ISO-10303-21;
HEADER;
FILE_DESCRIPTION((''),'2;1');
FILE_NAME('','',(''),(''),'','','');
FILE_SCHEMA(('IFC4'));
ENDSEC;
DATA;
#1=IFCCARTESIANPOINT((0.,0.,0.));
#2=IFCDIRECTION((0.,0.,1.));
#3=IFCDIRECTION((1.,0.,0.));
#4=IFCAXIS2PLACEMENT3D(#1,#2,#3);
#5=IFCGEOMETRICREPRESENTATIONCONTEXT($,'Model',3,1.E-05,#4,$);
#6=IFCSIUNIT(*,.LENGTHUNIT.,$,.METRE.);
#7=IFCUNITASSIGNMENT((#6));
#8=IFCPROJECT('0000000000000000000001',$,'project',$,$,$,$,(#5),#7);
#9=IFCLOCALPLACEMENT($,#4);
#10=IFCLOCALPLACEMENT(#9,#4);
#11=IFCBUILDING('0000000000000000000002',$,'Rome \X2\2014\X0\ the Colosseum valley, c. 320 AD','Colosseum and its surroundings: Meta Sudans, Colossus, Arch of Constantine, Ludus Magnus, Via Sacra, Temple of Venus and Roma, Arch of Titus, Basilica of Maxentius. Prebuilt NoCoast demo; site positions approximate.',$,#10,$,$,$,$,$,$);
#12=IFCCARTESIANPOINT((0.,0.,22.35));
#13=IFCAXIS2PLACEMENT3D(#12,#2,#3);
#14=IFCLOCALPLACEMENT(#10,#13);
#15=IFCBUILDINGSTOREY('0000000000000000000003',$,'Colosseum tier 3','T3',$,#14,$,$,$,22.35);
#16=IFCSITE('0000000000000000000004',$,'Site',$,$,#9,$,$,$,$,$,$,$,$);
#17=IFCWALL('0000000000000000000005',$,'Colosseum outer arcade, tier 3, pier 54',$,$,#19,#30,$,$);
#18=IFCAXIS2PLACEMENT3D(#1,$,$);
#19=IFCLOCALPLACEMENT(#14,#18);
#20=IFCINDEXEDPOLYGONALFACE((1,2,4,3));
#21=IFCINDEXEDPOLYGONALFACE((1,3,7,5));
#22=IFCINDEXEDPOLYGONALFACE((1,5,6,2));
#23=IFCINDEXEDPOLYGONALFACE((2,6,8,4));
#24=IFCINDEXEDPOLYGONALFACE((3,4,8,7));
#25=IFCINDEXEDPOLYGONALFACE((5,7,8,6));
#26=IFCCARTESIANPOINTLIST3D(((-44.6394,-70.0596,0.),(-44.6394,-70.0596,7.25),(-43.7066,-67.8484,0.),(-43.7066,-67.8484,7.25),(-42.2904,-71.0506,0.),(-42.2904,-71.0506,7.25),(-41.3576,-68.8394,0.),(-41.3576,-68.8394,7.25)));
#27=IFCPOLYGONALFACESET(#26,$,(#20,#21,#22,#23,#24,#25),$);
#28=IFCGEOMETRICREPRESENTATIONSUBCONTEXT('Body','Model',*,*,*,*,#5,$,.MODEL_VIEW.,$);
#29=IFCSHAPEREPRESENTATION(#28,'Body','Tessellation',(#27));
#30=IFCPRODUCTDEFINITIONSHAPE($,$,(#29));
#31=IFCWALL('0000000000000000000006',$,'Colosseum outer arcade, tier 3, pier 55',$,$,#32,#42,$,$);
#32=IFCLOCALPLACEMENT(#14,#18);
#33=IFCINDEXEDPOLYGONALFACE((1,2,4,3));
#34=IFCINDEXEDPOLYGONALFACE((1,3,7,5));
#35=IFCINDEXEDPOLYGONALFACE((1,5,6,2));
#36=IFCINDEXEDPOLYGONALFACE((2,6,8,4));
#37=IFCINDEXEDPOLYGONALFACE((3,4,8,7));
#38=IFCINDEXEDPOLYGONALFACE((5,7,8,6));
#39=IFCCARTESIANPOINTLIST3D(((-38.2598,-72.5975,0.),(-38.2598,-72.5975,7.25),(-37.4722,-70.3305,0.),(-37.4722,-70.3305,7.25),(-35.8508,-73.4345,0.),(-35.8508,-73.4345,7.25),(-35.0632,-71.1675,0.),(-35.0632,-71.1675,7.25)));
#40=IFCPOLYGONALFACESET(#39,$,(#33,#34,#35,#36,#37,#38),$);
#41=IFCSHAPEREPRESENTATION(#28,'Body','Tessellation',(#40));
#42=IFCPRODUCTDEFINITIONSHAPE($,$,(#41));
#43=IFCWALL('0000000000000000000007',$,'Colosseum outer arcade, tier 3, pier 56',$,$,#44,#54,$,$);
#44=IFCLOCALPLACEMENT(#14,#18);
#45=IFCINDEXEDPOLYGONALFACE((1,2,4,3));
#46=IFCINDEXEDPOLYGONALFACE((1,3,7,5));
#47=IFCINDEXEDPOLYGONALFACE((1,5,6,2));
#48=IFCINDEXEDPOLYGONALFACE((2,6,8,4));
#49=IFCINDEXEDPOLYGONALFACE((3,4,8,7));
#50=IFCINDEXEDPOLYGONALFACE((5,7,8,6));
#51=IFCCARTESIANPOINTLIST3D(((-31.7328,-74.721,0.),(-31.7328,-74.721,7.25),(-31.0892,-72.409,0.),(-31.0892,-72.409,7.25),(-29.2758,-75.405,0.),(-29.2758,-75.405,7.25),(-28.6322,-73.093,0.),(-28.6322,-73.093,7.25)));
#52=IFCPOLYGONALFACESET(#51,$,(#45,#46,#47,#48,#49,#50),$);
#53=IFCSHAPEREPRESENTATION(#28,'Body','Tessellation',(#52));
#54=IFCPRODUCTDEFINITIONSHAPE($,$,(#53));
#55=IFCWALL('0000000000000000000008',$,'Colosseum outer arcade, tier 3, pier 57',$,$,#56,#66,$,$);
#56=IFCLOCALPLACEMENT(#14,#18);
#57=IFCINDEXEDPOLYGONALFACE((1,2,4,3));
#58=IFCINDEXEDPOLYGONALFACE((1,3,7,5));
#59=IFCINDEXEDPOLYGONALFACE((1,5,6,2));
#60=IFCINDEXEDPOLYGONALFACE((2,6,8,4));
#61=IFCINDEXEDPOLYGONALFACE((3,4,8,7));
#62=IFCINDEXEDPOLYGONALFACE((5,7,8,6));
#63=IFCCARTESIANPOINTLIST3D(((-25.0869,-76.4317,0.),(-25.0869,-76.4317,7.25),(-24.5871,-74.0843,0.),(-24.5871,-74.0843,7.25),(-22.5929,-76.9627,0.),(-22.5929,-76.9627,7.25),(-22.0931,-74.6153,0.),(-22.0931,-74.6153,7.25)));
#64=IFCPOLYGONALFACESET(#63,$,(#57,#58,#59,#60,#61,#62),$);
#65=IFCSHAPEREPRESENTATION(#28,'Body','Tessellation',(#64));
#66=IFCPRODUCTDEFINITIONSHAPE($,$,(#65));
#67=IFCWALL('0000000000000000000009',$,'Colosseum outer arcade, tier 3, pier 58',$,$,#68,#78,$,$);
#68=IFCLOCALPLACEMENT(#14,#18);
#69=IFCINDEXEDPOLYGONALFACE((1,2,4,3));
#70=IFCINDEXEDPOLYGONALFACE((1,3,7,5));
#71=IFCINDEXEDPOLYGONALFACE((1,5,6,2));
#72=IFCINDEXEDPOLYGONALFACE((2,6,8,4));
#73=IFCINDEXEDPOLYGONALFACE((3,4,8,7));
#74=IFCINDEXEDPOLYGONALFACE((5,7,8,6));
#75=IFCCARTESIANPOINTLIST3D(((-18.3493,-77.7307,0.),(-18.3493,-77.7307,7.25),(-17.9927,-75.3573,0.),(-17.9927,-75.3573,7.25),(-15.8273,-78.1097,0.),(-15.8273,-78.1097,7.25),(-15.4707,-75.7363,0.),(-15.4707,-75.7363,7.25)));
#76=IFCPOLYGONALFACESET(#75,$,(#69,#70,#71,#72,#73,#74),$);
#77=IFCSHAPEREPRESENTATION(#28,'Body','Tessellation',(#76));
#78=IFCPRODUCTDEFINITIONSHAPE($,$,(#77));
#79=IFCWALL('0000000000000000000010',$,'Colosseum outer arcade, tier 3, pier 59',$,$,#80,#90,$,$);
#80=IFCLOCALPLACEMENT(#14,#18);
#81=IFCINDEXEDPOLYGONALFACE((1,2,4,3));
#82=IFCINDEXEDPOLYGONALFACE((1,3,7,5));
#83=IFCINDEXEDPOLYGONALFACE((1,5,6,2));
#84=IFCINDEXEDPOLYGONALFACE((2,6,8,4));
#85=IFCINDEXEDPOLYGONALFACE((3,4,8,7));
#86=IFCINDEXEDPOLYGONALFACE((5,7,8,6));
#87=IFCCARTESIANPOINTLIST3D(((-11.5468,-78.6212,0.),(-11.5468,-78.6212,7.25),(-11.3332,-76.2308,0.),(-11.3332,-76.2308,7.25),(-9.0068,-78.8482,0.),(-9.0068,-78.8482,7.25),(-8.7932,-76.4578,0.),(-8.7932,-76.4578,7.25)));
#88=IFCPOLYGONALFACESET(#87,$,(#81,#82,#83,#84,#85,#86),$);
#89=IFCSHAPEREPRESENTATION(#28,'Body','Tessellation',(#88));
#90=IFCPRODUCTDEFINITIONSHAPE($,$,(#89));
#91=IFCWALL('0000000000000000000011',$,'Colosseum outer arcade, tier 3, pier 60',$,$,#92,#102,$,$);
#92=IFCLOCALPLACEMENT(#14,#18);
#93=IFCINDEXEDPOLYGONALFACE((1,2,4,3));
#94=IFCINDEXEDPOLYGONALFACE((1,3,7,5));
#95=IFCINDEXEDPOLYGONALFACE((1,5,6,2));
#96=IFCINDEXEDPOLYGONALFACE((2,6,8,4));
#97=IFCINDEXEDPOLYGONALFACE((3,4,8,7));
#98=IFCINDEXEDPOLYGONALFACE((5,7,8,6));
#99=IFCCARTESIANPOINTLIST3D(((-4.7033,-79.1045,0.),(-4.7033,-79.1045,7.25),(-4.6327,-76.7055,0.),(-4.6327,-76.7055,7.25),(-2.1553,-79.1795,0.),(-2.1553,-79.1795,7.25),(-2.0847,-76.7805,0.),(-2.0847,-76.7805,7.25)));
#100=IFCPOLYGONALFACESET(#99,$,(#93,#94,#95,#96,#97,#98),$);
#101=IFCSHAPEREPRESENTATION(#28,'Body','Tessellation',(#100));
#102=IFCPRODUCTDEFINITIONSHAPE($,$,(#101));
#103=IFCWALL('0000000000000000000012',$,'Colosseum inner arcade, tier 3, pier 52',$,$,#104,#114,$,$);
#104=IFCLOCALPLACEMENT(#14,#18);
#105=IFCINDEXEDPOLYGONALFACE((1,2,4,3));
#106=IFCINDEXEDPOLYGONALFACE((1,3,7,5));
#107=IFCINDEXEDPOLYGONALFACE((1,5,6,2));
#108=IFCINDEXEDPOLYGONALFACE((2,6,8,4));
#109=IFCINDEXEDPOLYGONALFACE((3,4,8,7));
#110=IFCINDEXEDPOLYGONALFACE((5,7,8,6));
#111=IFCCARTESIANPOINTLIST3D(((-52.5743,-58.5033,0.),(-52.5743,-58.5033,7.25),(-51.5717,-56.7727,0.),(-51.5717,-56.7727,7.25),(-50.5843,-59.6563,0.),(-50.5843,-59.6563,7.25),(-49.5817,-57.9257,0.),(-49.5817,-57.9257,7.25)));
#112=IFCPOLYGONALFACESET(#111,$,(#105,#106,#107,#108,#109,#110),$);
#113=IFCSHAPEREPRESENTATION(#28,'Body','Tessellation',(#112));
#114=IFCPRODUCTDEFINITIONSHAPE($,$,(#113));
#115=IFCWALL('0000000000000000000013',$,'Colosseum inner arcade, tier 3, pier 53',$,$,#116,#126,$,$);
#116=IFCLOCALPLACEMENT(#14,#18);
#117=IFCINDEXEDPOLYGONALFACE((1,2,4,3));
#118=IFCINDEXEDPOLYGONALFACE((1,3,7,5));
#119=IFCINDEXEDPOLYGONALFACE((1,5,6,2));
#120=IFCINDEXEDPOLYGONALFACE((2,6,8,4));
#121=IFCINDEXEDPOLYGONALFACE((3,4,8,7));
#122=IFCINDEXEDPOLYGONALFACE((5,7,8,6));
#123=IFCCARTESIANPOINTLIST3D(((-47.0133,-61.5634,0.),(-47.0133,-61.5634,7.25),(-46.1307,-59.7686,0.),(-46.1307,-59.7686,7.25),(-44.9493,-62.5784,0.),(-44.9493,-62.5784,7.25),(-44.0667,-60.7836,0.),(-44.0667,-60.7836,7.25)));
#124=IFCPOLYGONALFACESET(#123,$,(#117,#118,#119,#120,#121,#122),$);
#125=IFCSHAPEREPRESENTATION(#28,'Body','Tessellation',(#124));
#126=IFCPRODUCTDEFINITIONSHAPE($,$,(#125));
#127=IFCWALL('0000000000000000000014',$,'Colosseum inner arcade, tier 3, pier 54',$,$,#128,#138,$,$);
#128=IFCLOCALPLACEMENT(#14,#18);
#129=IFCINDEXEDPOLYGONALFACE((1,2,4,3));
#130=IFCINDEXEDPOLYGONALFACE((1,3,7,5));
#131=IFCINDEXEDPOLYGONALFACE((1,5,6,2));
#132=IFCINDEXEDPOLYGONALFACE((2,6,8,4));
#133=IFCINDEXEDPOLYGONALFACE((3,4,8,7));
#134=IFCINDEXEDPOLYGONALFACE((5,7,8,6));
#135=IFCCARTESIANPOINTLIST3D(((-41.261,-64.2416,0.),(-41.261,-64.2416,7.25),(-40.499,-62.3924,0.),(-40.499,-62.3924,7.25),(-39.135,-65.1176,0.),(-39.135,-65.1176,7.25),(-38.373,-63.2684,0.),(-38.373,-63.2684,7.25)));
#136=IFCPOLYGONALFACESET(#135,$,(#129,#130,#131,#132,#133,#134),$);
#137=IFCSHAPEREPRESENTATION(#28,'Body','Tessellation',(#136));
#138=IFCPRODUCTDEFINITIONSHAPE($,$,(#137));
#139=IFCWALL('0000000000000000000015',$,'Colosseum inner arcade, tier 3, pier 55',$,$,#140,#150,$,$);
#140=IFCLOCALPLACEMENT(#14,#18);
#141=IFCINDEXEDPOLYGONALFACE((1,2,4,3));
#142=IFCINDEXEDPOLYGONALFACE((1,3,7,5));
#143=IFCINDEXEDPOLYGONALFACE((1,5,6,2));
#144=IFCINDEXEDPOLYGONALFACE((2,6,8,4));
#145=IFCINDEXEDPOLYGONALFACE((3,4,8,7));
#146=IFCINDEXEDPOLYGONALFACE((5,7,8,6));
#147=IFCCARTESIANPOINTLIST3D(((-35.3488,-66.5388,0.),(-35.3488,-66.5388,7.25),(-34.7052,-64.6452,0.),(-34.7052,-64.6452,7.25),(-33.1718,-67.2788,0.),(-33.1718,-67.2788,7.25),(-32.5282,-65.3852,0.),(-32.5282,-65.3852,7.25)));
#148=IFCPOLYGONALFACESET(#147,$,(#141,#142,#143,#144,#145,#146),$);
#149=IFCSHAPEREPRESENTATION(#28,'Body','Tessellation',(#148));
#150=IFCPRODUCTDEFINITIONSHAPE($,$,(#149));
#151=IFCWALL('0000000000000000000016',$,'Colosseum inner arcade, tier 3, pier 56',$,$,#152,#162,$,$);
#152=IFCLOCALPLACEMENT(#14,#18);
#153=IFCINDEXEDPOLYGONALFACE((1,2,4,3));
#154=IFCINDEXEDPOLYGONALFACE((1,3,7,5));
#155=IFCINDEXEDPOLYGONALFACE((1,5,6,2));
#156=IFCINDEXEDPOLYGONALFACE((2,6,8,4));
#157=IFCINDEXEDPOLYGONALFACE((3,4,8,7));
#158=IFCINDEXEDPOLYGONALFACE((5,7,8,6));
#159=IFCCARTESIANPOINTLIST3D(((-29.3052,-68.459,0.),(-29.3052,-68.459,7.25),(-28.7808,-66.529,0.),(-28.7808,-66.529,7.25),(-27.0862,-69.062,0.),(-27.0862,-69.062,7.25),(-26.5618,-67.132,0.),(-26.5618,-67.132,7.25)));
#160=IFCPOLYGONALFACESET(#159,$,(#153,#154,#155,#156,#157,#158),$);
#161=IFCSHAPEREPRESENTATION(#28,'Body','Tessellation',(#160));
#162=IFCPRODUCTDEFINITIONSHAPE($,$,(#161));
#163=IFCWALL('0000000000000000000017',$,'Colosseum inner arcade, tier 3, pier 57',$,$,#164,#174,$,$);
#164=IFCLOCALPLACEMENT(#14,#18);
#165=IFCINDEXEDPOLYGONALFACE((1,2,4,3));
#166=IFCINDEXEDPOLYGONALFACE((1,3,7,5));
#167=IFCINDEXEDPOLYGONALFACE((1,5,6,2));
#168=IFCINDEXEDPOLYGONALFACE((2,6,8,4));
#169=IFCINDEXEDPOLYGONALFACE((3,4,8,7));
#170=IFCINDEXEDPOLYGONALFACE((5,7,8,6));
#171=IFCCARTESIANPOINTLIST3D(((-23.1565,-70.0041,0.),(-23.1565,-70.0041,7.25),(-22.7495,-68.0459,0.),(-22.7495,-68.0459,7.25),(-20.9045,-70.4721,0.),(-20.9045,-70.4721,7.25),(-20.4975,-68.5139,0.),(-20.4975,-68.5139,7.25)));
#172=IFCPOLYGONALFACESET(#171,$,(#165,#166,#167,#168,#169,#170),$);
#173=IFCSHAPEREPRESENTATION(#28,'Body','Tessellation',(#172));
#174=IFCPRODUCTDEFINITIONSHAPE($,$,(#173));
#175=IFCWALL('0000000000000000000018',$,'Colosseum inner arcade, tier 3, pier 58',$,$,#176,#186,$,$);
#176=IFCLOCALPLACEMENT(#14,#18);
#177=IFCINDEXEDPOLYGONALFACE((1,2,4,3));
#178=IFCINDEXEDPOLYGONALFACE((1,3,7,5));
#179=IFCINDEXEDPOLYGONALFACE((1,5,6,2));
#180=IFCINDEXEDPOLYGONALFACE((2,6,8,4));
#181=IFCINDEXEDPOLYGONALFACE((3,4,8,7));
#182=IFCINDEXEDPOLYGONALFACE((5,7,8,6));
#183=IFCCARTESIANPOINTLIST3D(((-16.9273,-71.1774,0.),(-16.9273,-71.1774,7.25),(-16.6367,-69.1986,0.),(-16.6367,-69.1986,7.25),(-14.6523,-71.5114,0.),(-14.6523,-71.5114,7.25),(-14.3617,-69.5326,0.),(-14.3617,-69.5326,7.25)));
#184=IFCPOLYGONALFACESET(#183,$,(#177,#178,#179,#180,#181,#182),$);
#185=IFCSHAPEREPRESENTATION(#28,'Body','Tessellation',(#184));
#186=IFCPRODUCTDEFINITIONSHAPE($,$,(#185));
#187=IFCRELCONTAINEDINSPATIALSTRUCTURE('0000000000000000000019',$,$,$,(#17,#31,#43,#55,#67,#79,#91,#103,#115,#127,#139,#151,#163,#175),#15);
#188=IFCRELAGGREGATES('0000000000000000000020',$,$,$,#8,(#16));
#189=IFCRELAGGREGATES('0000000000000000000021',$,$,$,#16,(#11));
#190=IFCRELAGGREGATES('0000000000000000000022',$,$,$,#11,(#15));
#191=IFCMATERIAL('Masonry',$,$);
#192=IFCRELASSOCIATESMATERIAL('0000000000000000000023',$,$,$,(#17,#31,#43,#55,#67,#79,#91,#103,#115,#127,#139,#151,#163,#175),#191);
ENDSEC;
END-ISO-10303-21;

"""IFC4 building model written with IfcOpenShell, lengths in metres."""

from ifc_helpers import new_model, si_unit, frame, origin_with_axes, place, context, subcontext, project, spatial, indexed_curve, outline, extrude, material, element, save


model = new_model("IFC4")

# Units and contexts
model_context = context("Model", 3, precision=1e-05, world=origin_with_axes())
body_context = subcontext(model_context, "Body", "Model", "MODEL_VIEW")
ifc_project = project(units=[si_unit("LENGTHUNIT", "METRE")], contexts=[model_context])

# Site, building, storey
site_placement = place(None, origin_with_axes())
site = spatial("IfcSite", under=ifc_project, at=site_placement, Name="Site")
building_placement = place(site_placement, origin_with_axes())
building = spatial("IfcBuilding", under=site, at=building_placement, Name="Rome — the Colosseum valley, c. 320 AD", Description="Colosseum and its surroundings: Meta Sudans, Colossus, Arch of Constantine, Ludus Magnus, Via Sacra, Temple of Venus and Roma, Arch of Titus, Basilica of Maxentius. Prebuilt NoCoast demo; site positions approximate.")
storey_placement = place(building_placement, frame((0.0, 0.0, 22.35), z_axis=(0.0, 0.0, 1.0), x_axis=(1.0, 0.0, 0.0)))
storey = spatial("IfcBuildingStorey", under=building, at=storey_placement, Name="Colosseum tier 3", Description="T3", Elevation=22.35)

# Walls
ifc_material_1 = material(Name="Masonry")
wall_1_placement = place(storey_placement, frame((-44.173, -68.954, 0.0), z_axis=(0.0, 0.0, 1.0), x_axis=(0.921362, -0.388706, 0.0)))
element("IfcWall", 1, at=wall_1_placement, inside=storey, material=ifc_material_1, Name="Colosseum outer arcade, tier 3, pier 54", context=body_context, shape_type="SweptSolid", body=[
    extrude(outline(indexed_curve([(0.0, 0.0), (0.0, 2.4), (2.5495, 2.4), (2.5495, 0.0), (0.0, 0.0)], self_intersect=False)), frame((0.0, -1.2, 0.0), z_axis=(0.0, 0.0, 1.0), x_axis=(1.0, 0.0, 0.0)), (0.0, 0.0, 1.0), 7.25),
])
wall_2_placement = place(storey_placement, frame((-37.866, -71.464, 0.0), z_axis=(0.0, 0.0, 1.0), x_axis=(0.944608, -0.328201, 0.0)))
element("IfcWall", 2, at=wall_2_placement, inside=storey, material=ifc_material_1, Name="Colosseum outer arcade, tier 3, pier 55", context=body_context, shape_type="SweptSolid", body=[
    extrude(outline(indexed_curve([(0.0, 0.0), (0.0, 2.4), (2.5503, 2.4), (2.5503, 0.0), (0.0, 0.0)], self_intersect=False)), frame((0.0, -1.2, 0.0), z_axis=(0.0, 0.0, 1.0), x_axis=(1.0, 0.0, 0.0)), (0.0, 0.0, 1.0), 7.25),
])
wall_3_placement = place(storey_placement, frame((-31.411, -73.565, 0.0), z_axis=(0.0, 0.0, 1.0), x_axis=(0.963366, -0.26819, 0.0)))
element("IfcWall", 3, at=wall_3_placement, inside=storey, material=ifc_material_1, Name="Colosseum outer arcade, tier 3, pier 56", context=body_context, shape_type="SweptSolid", body=[
    extrude(outline(indexed_curve([(0.0, 0.0), (0.0, 2.4), (2.5504, 2.4), (2.5504, 0.0), (0.0, 0.0)], self_intersect=False)), frame((0.0, -1.2, 0.0), z_axis=(0.0, 0.0, 1.0), x_axis=(1.0, 0.0, 0.0)), (0.0, 0.0, 1.0), 7.25),
])
wall_4_placement = place(storey_placement, frame((-24.837, -75.258, 0.0), z_axis=(0.0, 0.0, 1.0), x_axis=(0.978077, -0.208243, 0.0)))
element("IfcWall", 4, at=wall_4_placement, inside=storey, material=ifc_material_1, Name="Colosseum outer arcade, tier 3, pier 57", context=body_context, shape_type="SweptSolid", body=[
    extrude(outline(indexed_curve([(0.0, 0.0), (0.0, 2.4), (2.5499, 2.4), (2.5499, 0.0), (0.0, 0.0)], self_intersect=False)), frame((0.0, -1.2, 0.0), z_axis=(0.0, 0.0, 1.0), x_axis=(1.0, 0.0, 0.0)), (0.0, 0.0, 1.0), 7.25),
])
wall_5_placement = place(storey_placement, frame((-18.171, -76.544, 0.0), z_axis=(0.0, 0.0, 1.0), x_axis=(0.988896, -0.148609, 0.0)))
element("IfcWall", 5, at=wall_5_placement, inside=storey, material=ifc_material_1, Name="Colosseum outer arcade, tier 3, pier 58", context=body_context, shape_type="SweptSolid", body=[
    extrude(outline(indexed_curve([(0.0, 0.0), (0.0, 2.4), (2.5503, 2.4), (2.5503, 0.0), (0.0, 0.0)], self_intersect=False)), frame((0.0, -1.2, 0.0), z_axis=(0.0, 0.0, 1.0), x_axis=(1.0, 0.0, 0.0)), (0.0, 0.0, 1.0), 7.25),
])
wall_6_placement = place(storey_placement, frame((-11.44, -77.426, 0.0), z_axis=(0.0, 0.0, 1.0), x_axis=(0.99603, -0.089015, 0.0)))
element("IfcWall", 6, at=wall_6_placement, inside=storey, material=ifc_material_1, Name="Colosseum outer arcade, tier 3, pier 59", context=body_context, shape_type="SweptSolid", body=[
    extrude(outline(indexed_curve([(0.0, 0.0), (0.0, 2.4), (2.5501, 2.4), (2.5501, 0.0), (0.0, 0.0)], self_intersect=False)), frame((0.0, -1.2, 0.0), z_axis=(0.0, 0.0, 1.0), x_axis=(1.0, 0.0, 0.0)), (0.0, 0.0, 1.0), 7.25),
])
wall_7_placement = place(storey_placement, frame((-4.668, -77.905, 0.0), z_axis=(0.0, 0.0, 1.0), x_axis=(0.999567, -0.029422, 0.0)))
element("IfcWall", 7, at=wall_7_placement, inside=storey, material=ifc_material_1, Name="Colosseum outer arcade, tier 3, pier 60", context=body_context, shape_type="SweptSolid", body=[
    extrude(outline(indexed_curve([(0.0, 0.0), (0.0, 2.4), (2.5491, 2.4), (2.5491, 0.0), (0.0, 0.0)], self_intersect=False)), frame((0.0, -1.2, 0.0), z_axis=(0.0, 0.0, 1.0), x_axis=(1.0, 0.0, 0.0)), (0.0, 0.0, 1.0), 7.25),
])
wall_8_placement = place(storey_placement, frame((-52.073, -57.638, 0.0), z_axis=(0.0, 0.0, 1.0), x_axis=(0.865258, -0.501328, 0.0)))
element("IfcWall", 8, at=wall_8_placement, inside=storey, material=ifc_material_1, Name="Colosseum inner arcade, tier 3, pier 52", context=body_context, shape_type="SweptSolid", body=[
    extrude(outline(indexed_curve([(0.0, 0.0), (0.0, 2.0), (2.2999, 2.0), (2.2999, 0.0), (0.0, 0.0)], self_intersect=False)), frame((0.0, -1.0, 0.0), z_axis=(0.0, 0.0, 1.0), x_axis=(1.0, 0.0, 0.0)), (0.0, 0.0, 1.0), 7.25),
])
wall_9_placement = place(storey_placement, frame((-46.572, -60.666, 0.0), z_axis=(0.0, 0.0, 1.0), x_axis=(0.897364, -0.441291, 0.0)))
element("IfcWall", 9, at=wall_9_placement, inside=storey, material=ifc_material_1, Name="Colosseum inner arcade, tier 3, pier 53", context=body_context, shape_type="SweptSolid", body=[
    extrude(outline(indexed_curve([(0.0, 0.0), (0.0, 2.0), (2.3001, 2.0), (2.3001, 0.0), (0.0, 0.0)], self_intersect=False)), frame((0.0, -1.0, 0.0), z_axis=(0.0, 0.0, 1.0), x_axis=(1.0, 0.0, 0.0)), (0.0, 0.0, 1.0), 7.25),
])
wall_10_placement = place(storey_placement, frame((-40.88, -63.317, 0.0), z_axis=(0.0, 0.0, 1.0), x_axis=(0.924588, -0.380969, 0.0)))
element("IfcWall", 10, at=wall_10_placement, inside=storey, material=ifc_material_1, Name="Colosseum inner arcade, tier 3, pier 54", context=body_context, shape_type="SweptSolid", body=[
    extrude(outline(indexed_curve([(0.0, 0.0), (0.0, 2.0), (2.2994, 2.0), (2.2994, 0.0), (0.0, 0.0)], self_intersect=False)), frame((0.0, -1.0, 0.0), z_axis=(0.0, 0.0, 1.0), x_axis=(1.0, 0.0, 0.0)), (0.0, 0.0, 1.0), 7.25),
])
wall_11_placement = place(storey_placement, frame((-35.027, -65.592, 0.0), z_axis=(0.0, 0.0, 1.0), x_axis=(0.946797, -0.321833, 0.0)))
element("IfcWall", 11, at=wall_11_placement, inside=storey, material=ifc_material_1, Name="Colosseum inner arcade, tier 3, pier 55", context=body_context, shape_type="SweptSolid", body=[
    extrude(outline(indexed_curve([(0.0, 0.0), (0.0, 2.0), (2.2993, 2.0), (2.2993, 0.0), (0.0, 0.0)], self_intersect=False)), frame((0.0, -1.0, 0.0), z_axis=(0.0, 0.0, 1.0), x_axis=(1.0, 0.0, 0.0)), (0.0, 0.0, 1.0), 7.25),
])
wall_12_placement = place(storey_placement, frame((-29.043, -67.494, 0.0), z_axis=(0.0, 0.0, 1.0), x_axis=(0.965004, -0.262234, 0.0)))
element("IfcWall", 12, at=wall_12_placement, inside=storey, material=ifc_material_1, Name="Colosseum inner arcade, tier 3, pier 56", context=body_context, shape_type="SweptSolid", body=[
    extrude(outline(indexed_curve([(0.0, 0.0), (0.0, 2.0), (2.2995, 2.0), (2.2995, 0.0), (0.0, 0.0)], self_intersect=False)), frame((0.0, -1.0, 0.0), z_axis=(0.0, 0.0, 1.0), x_axis=(1.0, 0.0, 0.0)), (0.0, 0.0, 1.0), 7.25),
])
wall_13_placement = place(storey_placement, frame((-22.953, -69.025, 0.0), z_axis=(0.0, 0.0, 1.0), x_axis=(0.979082, -0.203468, 0.0)))
element("IfcWall", 13, at=wall_13_placement, inside=storey, material=ifc_material_1, Name="Colosseum inner arcade, tier 3, pier 57", context=body_context, shape_type="SweptSolid", body=[
    extrude(outline(indexed_curve([(0.0, 0.0), (0.0, 2.0), (2.3001, 2.0), (2.3001, 0.0), (0.0, 0.0)], self_intersect=False)), frame((0.0, -1.0, 0.0), z_axis=(0.0, 0.0, 1.0), x_axis=(1.0, 0.0, 0.0)), (0.0, 0.0, 1.0), 7.25),
])
wall_14_placement = place(storey_placement, frame((-16.782, -70.188, 0.0), z_axis=(0.0, 0.0, 1.0), x_axis=(0.989394, -0.145256, 0.0)))
element("IfcWall", 14, at=wall_14_placement, inside=storey, material=ifc_material_1, Name="Colosseum inner arcade, tier 3, pier 58", context=body_context, shape_type="SweptSolid", body=[
    extrude(outline(indexed_curve([(0.0, 0.0), (0.0, 2.0), (2.2994, 2.0), (2.2994, 0.0), (0.0, 0.0)], self_intersect=False)), frame((0.0, -1.0, 0.0), z_axis=(0.0, 0.0, 1.0), x_axis=(1.0, 0.0, 0.0)), (0.0, 0.0, 1.0), 7.25),
])

save(model, "model.ifc")
